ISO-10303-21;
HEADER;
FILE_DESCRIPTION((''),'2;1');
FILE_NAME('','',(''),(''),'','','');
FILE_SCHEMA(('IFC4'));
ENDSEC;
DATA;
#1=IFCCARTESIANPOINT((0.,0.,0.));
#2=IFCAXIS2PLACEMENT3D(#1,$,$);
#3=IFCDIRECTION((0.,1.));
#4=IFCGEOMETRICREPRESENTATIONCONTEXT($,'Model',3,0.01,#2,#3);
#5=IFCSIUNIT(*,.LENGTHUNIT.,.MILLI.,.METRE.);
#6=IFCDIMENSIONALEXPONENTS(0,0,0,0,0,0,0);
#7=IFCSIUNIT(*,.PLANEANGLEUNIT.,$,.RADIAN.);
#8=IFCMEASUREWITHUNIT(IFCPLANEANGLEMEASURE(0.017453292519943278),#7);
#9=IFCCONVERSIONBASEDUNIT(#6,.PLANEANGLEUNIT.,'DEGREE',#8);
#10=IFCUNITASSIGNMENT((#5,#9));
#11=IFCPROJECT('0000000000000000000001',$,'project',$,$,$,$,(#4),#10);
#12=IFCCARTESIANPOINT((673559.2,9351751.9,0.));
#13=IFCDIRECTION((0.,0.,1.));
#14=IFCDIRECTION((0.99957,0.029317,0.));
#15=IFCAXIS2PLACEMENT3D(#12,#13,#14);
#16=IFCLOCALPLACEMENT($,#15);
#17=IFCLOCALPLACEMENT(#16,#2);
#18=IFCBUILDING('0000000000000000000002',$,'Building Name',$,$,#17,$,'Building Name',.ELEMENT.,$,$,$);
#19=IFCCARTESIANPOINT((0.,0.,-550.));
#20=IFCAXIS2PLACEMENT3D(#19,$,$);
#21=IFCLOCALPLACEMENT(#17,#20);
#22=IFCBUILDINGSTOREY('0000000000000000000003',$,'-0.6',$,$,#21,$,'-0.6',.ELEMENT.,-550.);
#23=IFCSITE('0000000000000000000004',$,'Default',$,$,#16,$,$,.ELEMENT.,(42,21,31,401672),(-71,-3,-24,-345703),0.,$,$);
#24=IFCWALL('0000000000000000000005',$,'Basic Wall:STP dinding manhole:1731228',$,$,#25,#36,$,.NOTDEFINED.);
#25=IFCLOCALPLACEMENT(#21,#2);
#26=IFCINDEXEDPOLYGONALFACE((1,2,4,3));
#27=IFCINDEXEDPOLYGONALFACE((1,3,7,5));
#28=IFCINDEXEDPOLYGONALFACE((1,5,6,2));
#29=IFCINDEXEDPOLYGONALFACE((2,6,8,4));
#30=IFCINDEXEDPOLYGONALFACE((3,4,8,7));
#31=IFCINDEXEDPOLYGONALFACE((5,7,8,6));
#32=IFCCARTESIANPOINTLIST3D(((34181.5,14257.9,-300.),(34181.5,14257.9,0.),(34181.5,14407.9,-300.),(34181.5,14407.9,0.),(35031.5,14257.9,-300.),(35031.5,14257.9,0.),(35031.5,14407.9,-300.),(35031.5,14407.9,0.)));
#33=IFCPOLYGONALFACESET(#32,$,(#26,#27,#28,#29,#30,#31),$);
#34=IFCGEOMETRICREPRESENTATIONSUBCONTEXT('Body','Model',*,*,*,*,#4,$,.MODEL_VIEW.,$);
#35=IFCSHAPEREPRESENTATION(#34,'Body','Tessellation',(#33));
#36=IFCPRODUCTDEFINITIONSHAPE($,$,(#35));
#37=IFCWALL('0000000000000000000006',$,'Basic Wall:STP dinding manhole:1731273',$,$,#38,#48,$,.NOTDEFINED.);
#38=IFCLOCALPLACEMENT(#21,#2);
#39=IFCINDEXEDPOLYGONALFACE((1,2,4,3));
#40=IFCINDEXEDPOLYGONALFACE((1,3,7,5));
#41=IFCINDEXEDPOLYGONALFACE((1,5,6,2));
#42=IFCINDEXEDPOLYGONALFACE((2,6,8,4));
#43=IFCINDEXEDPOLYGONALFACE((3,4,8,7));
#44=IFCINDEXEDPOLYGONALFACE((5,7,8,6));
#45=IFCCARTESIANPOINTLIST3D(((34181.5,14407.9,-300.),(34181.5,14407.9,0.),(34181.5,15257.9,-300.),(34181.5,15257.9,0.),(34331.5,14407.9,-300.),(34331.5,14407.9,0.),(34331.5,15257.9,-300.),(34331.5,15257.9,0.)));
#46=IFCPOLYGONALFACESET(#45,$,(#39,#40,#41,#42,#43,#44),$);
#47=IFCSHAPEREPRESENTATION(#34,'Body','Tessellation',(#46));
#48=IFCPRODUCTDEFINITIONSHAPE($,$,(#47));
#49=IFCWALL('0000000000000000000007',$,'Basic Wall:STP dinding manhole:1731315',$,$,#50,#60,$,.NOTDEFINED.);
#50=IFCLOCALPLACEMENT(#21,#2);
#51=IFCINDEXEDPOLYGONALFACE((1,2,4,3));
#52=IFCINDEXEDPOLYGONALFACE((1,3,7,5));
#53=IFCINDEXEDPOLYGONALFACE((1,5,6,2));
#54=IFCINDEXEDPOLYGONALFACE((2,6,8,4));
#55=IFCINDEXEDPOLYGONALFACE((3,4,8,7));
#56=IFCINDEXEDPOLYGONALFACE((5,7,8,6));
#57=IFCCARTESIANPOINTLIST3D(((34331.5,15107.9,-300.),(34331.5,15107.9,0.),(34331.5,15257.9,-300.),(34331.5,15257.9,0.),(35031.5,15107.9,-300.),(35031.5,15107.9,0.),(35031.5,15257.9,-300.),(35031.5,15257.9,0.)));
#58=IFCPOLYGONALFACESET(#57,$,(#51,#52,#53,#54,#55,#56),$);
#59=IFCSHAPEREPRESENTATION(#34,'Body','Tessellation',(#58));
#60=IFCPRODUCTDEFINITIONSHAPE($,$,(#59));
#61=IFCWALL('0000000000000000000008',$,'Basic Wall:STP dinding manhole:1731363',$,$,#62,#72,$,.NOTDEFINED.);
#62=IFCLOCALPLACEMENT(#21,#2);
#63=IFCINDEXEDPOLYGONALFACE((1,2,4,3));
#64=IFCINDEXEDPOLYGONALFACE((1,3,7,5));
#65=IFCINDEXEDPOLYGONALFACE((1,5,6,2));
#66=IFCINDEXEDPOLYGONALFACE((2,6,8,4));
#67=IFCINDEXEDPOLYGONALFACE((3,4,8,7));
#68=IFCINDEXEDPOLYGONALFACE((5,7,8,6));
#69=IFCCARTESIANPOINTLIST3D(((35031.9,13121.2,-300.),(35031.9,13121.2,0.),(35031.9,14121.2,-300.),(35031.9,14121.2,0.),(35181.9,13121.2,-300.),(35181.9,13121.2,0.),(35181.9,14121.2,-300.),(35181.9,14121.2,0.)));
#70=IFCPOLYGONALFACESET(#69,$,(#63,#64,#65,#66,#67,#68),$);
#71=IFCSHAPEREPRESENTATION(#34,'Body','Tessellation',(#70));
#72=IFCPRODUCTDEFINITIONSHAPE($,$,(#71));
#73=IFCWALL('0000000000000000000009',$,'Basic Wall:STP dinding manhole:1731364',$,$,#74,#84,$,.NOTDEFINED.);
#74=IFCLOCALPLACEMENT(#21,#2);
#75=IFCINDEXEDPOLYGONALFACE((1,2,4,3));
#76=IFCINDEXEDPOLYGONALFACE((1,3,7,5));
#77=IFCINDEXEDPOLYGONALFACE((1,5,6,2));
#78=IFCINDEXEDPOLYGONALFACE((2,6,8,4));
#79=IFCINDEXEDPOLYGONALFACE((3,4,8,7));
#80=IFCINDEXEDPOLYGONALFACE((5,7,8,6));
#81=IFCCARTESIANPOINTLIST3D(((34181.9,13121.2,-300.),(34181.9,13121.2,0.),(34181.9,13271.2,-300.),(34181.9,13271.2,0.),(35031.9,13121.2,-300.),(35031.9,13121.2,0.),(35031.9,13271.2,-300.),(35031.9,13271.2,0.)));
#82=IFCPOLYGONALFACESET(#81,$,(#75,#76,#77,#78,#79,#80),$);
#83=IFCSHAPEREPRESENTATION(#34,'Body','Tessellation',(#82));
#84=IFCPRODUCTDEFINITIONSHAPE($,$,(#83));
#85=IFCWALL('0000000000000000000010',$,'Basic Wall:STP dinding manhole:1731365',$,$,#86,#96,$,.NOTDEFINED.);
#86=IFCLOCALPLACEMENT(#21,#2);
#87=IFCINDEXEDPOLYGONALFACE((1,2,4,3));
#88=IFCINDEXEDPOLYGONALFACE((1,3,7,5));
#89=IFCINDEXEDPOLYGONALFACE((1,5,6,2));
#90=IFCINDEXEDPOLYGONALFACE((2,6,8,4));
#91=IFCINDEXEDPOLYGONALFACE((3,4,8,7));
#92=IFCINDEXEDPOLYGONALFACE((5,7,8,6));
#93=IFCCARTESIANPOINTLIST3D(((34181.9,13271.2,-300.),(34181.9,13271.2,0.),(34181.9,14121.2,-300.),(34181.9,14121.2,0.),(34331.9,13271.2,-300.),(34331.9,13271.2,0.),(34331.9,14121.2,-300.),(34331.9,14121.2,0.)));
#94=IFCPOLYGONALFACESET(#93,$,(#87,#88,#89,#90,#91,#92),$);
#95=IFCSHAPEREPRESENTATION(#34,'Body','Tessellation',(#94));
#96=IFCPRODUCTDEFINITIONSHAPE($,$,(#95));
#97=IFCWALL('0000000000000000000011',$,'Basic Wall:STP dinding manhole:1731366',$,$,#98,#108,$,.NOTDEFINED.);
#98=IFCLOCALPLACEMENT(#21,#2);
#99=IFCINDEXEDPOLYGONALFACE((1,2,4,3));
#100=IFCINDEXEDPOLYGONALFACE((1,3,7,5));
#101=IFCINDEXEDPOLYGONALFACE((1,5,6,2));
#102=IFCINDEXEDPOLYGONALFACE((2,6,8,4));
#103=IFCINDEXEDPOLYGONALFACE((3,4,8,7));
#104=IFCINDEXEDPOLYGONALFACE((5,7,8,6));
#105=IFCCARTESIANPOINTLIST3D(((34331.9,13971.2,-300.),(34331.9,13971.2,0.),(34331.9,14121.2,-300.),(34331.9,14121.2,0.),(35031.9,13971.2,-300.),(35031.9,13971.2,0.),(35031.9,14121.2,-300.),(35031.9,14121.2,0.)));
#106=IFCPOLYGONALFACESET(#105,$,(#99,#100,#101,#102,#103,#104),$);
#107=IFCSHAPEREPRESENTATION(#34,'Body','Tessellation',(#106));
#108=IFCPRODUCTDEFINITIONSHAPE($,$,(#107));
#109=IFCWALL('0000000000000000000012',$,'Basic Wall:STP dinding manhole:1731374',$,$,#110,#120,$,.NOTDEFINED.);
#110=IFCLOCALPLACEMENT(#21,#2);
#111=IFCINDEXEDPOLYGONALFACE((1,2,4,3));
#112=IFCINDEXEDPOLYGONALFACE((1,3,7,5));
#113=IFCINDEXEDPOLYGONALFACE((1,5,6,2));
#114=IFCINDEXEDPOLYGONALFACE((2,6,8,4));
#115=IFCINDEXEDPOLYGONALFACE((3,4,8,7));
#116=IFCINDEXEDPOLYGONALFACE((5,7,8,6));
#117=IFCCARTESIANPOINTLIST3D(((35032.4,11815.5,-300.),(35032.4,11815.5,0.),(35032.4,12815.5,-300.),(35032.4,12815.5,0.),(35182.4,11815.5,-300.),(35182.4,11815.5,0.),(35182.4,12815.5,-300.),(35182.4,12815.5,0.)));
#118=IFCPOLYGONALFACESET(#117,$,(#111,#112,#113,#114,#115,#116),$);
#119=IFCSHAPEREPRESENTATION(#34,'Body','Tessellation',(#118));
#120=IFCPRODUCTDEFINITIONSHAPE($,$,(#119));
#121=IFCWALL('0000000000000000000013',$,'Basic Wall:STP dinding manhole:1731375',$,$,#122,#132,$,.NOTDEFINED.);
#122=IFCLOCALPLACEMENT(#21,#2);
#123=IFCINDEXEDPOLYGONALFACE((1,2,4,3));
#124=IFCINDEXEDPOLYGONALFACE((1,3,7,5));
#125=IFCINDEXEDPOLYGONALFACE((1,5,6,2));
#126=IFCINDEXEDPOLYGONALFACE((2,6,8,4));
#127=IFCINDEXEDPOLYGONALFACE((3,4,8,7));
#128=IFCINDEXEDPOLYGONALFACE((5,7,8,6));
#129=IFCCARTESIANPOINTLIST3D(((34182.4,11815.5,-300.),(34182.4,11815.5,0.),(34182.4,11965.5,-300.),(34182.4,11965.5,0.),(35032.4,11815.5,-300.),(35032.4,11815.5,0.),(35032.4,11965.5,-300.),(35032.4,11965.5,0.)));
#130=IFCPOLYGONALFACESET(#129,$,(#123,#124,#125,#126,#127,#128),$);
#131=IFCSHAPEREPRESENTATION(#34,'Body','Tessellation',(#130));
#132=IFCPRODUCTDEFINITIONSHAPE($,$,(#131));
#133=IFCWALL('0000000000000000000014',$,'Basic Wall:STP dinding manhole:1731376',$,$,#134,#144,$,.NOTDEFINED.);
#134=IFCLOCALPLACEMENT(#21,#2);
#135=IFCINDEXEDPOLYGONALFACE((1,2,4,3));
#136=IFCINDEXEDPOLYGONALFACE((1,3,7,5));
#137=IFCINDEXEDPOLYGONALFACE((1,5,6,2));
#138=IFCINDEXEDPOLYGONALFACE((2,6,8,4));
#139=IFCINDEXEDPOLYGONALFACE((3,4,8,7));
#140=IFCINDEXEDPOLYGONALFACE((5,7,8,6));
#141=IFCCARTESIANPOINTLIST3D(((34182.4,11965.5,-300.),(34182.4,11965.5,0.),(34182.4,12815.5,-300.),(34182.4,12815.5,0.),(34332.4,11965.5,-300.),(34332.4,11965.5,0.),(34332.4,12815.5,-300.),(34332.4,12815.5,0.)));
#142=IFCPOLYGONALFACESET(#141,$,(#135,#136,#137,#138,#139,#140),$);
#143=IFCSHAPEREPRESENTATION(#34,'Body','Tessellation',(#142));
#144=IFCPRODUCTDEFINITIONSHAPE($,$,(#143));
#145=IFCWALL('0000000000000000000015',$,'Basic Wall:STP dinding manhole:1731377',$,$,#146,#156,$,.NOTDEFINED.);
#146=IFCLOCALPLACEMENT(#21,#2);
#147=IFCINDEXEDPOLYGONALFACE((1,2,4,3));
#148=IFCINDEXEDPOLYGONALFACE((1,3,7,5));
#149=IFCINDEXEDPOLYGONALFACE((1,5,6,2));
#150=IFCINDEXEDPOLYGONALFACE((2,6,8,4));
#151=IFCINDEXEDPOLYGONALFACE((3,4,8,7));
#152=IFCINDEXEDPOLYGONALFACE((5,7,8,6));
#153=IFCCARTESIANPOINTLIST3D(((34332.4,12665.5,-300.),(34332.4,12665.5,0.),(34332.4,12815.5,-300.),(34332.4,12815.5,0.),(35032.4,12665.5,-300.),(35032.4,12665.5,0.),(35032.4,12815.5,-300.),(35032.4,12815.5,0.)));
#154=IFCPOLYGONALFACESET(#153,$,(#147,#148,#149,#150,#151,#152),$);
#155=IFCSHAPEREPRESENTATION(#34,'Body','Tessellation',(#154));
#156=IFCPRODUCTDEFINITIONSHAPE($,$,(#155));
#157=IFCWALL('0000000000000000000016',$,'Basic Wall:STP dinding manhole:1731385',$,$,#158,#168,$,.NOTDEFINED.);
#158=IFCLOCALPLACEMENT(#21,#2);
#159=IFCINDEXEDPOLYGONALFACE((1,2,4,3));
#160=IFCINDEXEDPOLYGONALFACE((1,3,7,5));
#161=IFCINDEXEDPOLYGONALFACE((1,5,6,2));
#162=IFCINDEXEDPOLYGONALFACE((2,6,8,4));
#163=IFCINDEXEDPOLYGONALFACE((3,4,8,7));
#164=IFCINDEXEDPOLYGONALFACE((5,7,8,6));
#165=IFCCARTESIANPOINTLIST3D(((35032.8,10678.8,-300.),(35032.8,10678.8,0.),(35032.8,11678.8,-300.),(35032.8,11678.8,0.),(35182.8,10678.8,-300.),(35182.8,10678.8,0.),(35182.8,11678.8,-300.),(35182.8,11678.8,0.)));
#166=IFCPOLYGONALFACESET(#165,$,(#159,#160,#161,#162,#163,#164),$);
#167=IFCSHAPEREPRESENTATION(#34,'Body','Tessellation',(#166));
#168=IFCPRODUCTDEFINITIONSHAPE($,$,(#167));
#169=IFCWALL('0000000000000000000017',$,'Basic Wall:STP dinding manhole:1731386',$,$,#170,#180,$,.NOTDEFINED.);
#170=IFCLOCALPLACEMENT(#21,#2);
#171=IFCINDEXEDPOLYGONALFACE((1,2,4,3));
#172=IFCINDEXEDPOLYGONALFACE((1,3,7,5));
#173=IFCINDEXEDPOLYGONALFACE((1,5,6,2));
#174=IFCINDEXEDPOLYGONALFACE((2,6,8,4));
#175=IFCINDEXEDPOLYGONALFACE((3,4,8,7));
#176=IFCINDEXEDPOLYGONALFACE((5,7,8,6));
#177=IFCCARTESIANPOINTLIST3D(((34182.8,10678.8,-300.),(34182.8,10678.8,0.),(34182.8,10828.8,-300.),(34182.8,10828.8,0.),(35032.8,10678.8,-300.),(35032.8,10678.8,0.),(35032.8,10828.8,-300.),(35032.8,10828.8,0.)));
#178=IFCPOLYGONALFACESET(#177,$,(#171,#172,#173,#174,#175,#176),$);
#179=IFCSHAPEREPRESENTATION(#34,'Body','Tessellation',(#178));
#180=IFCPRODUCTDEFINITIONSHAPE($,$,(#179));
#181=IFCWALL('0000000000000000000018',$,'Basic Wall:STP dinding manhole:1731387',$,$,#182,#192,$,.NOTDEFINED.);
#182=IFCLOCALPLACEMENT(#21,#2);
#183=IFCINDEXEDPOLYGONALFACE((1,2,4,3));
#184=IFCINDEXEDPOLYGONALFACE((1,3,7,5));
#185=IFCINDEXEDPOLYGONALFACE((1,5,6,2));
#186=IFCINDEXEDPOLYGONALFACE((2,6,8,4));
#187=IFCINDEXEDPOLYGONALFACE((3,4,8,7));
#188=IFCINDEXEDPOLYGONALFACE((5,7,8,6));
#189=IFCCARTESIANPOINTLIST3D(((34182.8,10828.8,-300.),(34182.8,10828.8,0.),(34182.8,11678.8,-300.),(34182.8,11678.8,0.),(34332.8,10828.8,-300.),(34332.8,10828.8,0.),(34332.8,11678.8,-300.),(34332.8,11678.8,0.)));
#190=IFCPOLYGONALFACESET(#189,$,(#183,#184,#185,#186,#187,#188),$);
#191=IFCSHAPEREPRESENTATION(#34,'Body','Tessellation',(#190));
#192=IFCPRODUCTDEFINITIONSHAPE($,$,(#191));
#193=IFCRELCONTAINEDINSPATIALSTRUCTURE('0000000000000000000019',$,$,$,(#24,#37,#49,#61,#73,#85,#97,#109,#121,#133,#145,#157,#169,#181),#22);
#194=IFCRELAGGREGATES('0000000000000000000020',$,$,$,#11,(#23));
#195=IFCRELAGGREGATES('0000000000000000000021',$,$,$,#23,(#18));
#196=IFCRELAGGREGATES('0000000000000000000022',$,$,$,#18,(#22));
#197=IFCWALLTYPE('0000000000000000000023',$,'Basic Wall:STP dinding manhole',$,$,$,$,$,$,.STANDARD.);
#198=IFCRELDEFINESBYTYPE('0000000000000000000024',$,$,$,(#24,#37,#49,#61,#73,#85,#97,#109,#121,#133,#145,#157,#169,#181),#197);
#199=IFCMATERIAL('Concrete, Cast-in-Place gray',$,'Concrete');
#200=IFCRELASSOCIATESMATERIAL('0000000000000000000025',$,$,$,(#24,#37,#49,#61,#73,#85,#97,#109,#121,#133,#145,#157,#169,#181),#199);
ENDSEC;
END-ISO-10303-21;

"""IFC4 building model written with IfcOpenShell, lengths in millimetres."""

from ifc_helpers import new_model, entity, si_unit, converted_unit, direction, frame, origin, place, context, subcontext, project, spatial, indexed_curve, outline, extrude, material, type_object, element, save


model = new_model("IFC4")

# Units and contexts
model_context = context("Model", 3, precision=0.01, world=origin(), true_north=direction((0.0, 1.0)))
body_context = subcontext(model_context, "Body", "Model", "MODEL_VIEW")
ifc_project = project(units=[si_unit("LENGTHUNIT", "METRE", prefix="MILLI"), converted_unit("PLANEANGLEUNIT", "DEGREE", entity("IfcPlaneAngleMeasure", 0.017453292519943278), si_unit("PLANEANGLEUNIT", "RADIAN"), dimensions=[0, 0, 0, 0, 0, 0, 0])], contexts=[model_context])

# Site, building, storey
site_placement = place(None, frame((673559.2, 9351751.9, 0.0), z_axis=(0.0, 0.0, 1.0), x_axis=(0.99957, 0.029317, 0.0)))
site = spatial("IfcSite", under=ifc_project, at=site_placement, Name="Default", CompositionType="ELEMENT", RefLatitude=(42, 21, 31, 401672), RefLongitude=(-71, -3, -24, -345703), RefElevation=0.0)
building_placement = place(site_placement, origin())
building = spatial("IfcBuilding", under=site, at=building_placement, Name="Building Name", LongName="Building Name", CompositionType="ELEMENT")
storey_placement = place(building_placement, frame((0.0, 0.0, -550.0)))
storey = spatial("IfcBuildingStorey", under=building, at=storey_placement, Name="-0.6", LongName="-0.6", CompositionType="ELEMENT", Elevation=-550.0)

# Walls
ifc_material_1 = material(Name="Concrete, Cast-in-Place gray", Category="Concrete")
wall_type_1 = type_object("IfcWallType", Name="Basic Wall:STP dinding manhole", PredefinedType="STANDARD")
wall_1_placement = place(storey_placement, frame((35031.5, 14332.9, -300.0), z_axis=(0.0, 0.0, 1.0), x_axis=(-1.0, 0.0, 0.0)))
element("IfcWall", 1, at=wall_1_placement, inside=storey, type_object=wall_type_1, material=ifc_material_1, Name="Basic Wall:STP dinding manhole:1731228", PredefinedType="NOTDEFINED", context=body_context, shape_type="SweptSolid", body=[
    extrude(outline(indexed_curve([(850.0, 75.0), (0.0, 75.0), (0.0, -75.0), (850.0, -75.0), (850.0, 75.0)], self_intersect=False)), origin(), (0.0, 0.0, 1.0), 300.0),
])
wall_2_placement = place(storey_placement, frame((34256.5, 14407.9, -300.0), z_axis=(0.0, 0.0, 1.0), x_axis=(0.0, 1.0, 0.0)))
element("IfcWall", 2, at=wall_2_placement, inside=storey, type_object=wall_type_1, material=ifc_material_1, Name="Basic Wall:STP dinding manhole:1731273", PredefinedType="NOTDEFINED", context=body_context, shape_type="SweptSolid", body=[
    extrude(outline(indexed_curve([(850.0, 75.0), (0.0, 75.0), (0.0, -75.0), (850.0, -75.0), (850.0, 75.0)], self_intersect=False)), origin(), (0.0, 0.0, 1.0), 300.0),
])
wall_3_placement = place(storey_placement, frame((34331.5, 15182.9, -300.0)))
element("IfcWall", 3, at=wall_3_placement, inside=storey, type_object=wall_type_1, material=ifc_material_1, Name="Basic Wall:STP dinding manhole:1731315", PredefinedType="NOTDEFINED", context=body_context, shape_type="SweptSolid", body=[
    extrude(outline(indexed_curve([(700.0, 75.0), (0.0, 75.0), (0.0, -75.0), (700.0, -75.0), (700.0, 75.0)], self_intersect=False)), origin(), (0.0, 0.0, 1.0), 300.0),
])
wall_4_placement = place(storey_placement, frame((35106.9, 14121.2, -300.0), z_axis=(0.0, 0.0, 1.0), x_axis=(0.0, -1.0, 0.0)))
element("IfcWall", 4, at=wall_4_placement, inside=storey, type_object=wall_type_1, material=ifc_material_1, Name="Basic Wall:STP dinding manhole:1731363", PredefinedType="NOTDEFINED", context=body_context, shape_type="SweptSolid", body=[
    extrude(outline(indexed_curve([(1000.0, 75.0), (0.0, 75.0), (0.0, -75.0), (1000.0, -75.0), (1000.0, 75.0)], self_intersect=False)), origin(), (0.0, 0.0, 1.0), 300.0),
])
wall_5_placement = place(storey_placement, frame((35031.9, 13196.2, -300.0), z_axis=(0.0, 0.0, 1.0), x_axis=(-1.0, 0.0, 0.0)))
element("IfcWall", 5, at=wall_5_placement, inside=storey, type_object=wall_type_1, material=ifc_material_1, Name="Basic Wall:STP dinding manhole:1731364", PredefinedType="NOTDEFINED", context=body_context, shape_type="SweptSolid", body=[
    extrude(outline(indexed_curve([(850.0, 75.0), (0.0, 75.0), (0.0, -75.0), (850.0, -75.0), (850.0, 75.0)], self_intersect=False)), origin(), (0.0, 0.0, 1.0), 300.0),
])
wall_6_placement = place(storey_placement, frame((34256.9, 13271.2, -300.0), z_axis=(0.0, 0.0, 1.0), x_axis=(0.0, 1.0, 0.0)))
element("IfcWall", 6, at=wall_6_placement, inside=storey, type_object=wall_type_1, material=ifc_material_1, Name="Basic Wall:STP dinding manhole:1731365", PredefinedType="NOTDEFINED", context=body_context, shape_type="SweptSolid", body=[
    extrude(outline(indexed_curve([(850.0, 75.0), (0.0, 75.0), (0.0, -75.0), (850.0, -75.0), (850.0, 75.0)], self_intersect=False)), origin(), (0.0, 0.0, 1.0), 300.0),
])
wall_7_placement = place(storey_placement, frame((34331.9, 14046.2, -300.0)))
element("IfcWall", 7, at=wall_7_placement, inside=storey, type_object=wall_type_1, material=ifc_material_1, Name="Basic Wall:STP dinding manhole:1731366", PredefinedType="NOTDEFINED", context=body_context, shape_type="SweptSolid", body=[
    extrude(outline(indexed_curve([(700.0, 75.0), (0.0, 75.0), (0.0, -75.0), (700.0, -75.0), (700.0, 75.0)], self_intersect=False)), origin(), (0.0, 0.0, 1.0), 300.0),
])
wall_8_placement = place(storey_placement, frame((35107.4, 12815.5, -300.0), z_axis=(0.0, 0.0, 1.0), x_axis=(0.0, -1.0, 0.0)))
element("IfcWall", 8, at=wall_8_placement, inside=storey, type_object=wall_type_1, material=ifc_material_1, Name="Basic Wall:STP dinding manhole:1731374", PredefinedType="NOTDEFINED", context=body_context, shape_type="SweptSolid", body=[
    extrude(outline(indexed_curve([(1000.0, 75.0), (0.0, 75.0), (0.0, -75.0), (1000.0, -75.0), (1000.0, 75.0)], self_intersect=False)), origin(), (0.0, 0.0, 1.0), 300.0),
])
wall_9_placement = place(storey_placement, frame((35032.4, 11890.5, -300.0), z_axis=(0.0, 0.0, 1.0), x_axis=(-1.0, 0.0, 0.0)))
element("IfcWall", 9, at=wall_9_placement, inside=storey, type_object=wall_type_1, material=ifc_material_1, Name="Basic Wall:STP dinding manhole:1731375", PredefinedType="NOTDEFINED", context=body_context, shape_type="SweptSolid", body=[
    extrude(outline(indexed_curve([(850.0, 75.0), (0.0, 75.0), (0.0, -75.0), (850.0, -75.0), (850.0, 75.0)], self_intersect=False)), origin(), (0.0, 0.0, 1.0), 300.0),
])
wall_10_placement = place(storey_placement, frame((34257.4, 11965.5, -300.0), z_axis=(0.0, 0.0, 1.0), x_axis=(0.0, 1.0, 0.0)))
element("IfcWall", 10, at=wall_10_placement, inside=storey, type_object=wall_type_1, material=ifc_material_1, Name="Basic Wall:STP dinding manhole:1731376", PredefinedType="NOTDEFINED", context=body_context, shape_type="SweptSolid", body=[
    extrude(outline(indexed_curve([(850.0, 75.0), (0.0, 75.0), (0.0, -75.0), (850.0, -75.0), (850.0, 75.0)], self_intersect=False)), origin(), (0.0, 0.0, 1.0), 300.0),
])
wall_11_placement = place(storey_placement, frame((34332.4, 12740.5, -300.0)))
element("IfcWall", 11, at=wall_11_placement, inside=storey, type_object=wall_type_1, material=ifc_material_1, Name="Basic Wall:STP dinding manhole:1731377", PredefinedType="NOTDEFINED", context=body_context, shape_type="SweptSolid", body=[
    extrude(outline(indexed_curve([(700.0, 75.0), (0.0, 75.0), (0.0, -75.0), (700.0, -75.0), (700.0, 75.0)], self_intersect=False)), origin(), (0.0, 0.0, 1.0), 300.0),
])
wall_12_placement = place(storey_placement, frame((35107.8, 11678.8, -300.0), z_axis=(0.0, 0.0, 1.0), x_axis=(0.0, -1.0, 0.0)))
element("IfcWall", 12, at=wall_12_placement, inside=storey, type_object=wall_type_1, material=ifc_material_1, Name="Basic Wall:STP dinding manhole:1731385", PredefinedType="NOTDEFINED", context=body_context, shape_type="SweptSolid", body=[
    extrude(outline(indexed_curve([(1000.0, 75.0), (0.0, 75.0), (0.0, -75.0), (1000.0, -75.0), (1000.0, 75.0)], self_intersect=False)), origin(), (0.0, 0.0, 1.0), 300.0),
])
wall_13_placement = place(storey_placement, frame((35032.8, 10753.8, -300.0), z_axis=(0.0, 0.0, 1.0), x_axis=(-1.0, 0.0, 0.0)))
element("IfcWall", 13, at=wall_13_placement, inside=storey, type_object=wall_type_1, material=ifc_material_1, Name="Basic Wall:STP dinding manhole:1731386", PredefinedType="NOTDEFINED", context=body_context, shape_type="SweptSolid", body=[
    extrude(outline(indexed_curve([(850.0, 75.0), (0.0, 75.0), (0.0, -75.0), (850.0, -75.0), (850.0, 75.0)], self_intersect=False)), origin(), (0.0, 0.0, 1.0), 300.0),
])
wall_14_placement = place(storey_placement, frame((34257.8, 10828.8, -300.0), z_axis=(0.0, 0.0, 1.0), x_axis=(0.0, 1.0, 0.0)))
element("IfcWall", 14, at=wall_14_placement, inside=storey, type_object=wall_type_1, material=ifc_material_1, Name="Basic Wall:STP dinding manhole:1731387", PredefinedType="NOTDEFINED", context=body_context, shape_type="SweptSolid", body=[
    extrude(outline(indexed_curve([(850.0, 75.0), (0.0, 75.0), (0.0, -75.0), (850.0, -75.0), (850.0, 75.0)], self_intersect=False)), origin(), (0.0, 0.0, 1.0), 300.0),
])

save(model, "model.ifc")
